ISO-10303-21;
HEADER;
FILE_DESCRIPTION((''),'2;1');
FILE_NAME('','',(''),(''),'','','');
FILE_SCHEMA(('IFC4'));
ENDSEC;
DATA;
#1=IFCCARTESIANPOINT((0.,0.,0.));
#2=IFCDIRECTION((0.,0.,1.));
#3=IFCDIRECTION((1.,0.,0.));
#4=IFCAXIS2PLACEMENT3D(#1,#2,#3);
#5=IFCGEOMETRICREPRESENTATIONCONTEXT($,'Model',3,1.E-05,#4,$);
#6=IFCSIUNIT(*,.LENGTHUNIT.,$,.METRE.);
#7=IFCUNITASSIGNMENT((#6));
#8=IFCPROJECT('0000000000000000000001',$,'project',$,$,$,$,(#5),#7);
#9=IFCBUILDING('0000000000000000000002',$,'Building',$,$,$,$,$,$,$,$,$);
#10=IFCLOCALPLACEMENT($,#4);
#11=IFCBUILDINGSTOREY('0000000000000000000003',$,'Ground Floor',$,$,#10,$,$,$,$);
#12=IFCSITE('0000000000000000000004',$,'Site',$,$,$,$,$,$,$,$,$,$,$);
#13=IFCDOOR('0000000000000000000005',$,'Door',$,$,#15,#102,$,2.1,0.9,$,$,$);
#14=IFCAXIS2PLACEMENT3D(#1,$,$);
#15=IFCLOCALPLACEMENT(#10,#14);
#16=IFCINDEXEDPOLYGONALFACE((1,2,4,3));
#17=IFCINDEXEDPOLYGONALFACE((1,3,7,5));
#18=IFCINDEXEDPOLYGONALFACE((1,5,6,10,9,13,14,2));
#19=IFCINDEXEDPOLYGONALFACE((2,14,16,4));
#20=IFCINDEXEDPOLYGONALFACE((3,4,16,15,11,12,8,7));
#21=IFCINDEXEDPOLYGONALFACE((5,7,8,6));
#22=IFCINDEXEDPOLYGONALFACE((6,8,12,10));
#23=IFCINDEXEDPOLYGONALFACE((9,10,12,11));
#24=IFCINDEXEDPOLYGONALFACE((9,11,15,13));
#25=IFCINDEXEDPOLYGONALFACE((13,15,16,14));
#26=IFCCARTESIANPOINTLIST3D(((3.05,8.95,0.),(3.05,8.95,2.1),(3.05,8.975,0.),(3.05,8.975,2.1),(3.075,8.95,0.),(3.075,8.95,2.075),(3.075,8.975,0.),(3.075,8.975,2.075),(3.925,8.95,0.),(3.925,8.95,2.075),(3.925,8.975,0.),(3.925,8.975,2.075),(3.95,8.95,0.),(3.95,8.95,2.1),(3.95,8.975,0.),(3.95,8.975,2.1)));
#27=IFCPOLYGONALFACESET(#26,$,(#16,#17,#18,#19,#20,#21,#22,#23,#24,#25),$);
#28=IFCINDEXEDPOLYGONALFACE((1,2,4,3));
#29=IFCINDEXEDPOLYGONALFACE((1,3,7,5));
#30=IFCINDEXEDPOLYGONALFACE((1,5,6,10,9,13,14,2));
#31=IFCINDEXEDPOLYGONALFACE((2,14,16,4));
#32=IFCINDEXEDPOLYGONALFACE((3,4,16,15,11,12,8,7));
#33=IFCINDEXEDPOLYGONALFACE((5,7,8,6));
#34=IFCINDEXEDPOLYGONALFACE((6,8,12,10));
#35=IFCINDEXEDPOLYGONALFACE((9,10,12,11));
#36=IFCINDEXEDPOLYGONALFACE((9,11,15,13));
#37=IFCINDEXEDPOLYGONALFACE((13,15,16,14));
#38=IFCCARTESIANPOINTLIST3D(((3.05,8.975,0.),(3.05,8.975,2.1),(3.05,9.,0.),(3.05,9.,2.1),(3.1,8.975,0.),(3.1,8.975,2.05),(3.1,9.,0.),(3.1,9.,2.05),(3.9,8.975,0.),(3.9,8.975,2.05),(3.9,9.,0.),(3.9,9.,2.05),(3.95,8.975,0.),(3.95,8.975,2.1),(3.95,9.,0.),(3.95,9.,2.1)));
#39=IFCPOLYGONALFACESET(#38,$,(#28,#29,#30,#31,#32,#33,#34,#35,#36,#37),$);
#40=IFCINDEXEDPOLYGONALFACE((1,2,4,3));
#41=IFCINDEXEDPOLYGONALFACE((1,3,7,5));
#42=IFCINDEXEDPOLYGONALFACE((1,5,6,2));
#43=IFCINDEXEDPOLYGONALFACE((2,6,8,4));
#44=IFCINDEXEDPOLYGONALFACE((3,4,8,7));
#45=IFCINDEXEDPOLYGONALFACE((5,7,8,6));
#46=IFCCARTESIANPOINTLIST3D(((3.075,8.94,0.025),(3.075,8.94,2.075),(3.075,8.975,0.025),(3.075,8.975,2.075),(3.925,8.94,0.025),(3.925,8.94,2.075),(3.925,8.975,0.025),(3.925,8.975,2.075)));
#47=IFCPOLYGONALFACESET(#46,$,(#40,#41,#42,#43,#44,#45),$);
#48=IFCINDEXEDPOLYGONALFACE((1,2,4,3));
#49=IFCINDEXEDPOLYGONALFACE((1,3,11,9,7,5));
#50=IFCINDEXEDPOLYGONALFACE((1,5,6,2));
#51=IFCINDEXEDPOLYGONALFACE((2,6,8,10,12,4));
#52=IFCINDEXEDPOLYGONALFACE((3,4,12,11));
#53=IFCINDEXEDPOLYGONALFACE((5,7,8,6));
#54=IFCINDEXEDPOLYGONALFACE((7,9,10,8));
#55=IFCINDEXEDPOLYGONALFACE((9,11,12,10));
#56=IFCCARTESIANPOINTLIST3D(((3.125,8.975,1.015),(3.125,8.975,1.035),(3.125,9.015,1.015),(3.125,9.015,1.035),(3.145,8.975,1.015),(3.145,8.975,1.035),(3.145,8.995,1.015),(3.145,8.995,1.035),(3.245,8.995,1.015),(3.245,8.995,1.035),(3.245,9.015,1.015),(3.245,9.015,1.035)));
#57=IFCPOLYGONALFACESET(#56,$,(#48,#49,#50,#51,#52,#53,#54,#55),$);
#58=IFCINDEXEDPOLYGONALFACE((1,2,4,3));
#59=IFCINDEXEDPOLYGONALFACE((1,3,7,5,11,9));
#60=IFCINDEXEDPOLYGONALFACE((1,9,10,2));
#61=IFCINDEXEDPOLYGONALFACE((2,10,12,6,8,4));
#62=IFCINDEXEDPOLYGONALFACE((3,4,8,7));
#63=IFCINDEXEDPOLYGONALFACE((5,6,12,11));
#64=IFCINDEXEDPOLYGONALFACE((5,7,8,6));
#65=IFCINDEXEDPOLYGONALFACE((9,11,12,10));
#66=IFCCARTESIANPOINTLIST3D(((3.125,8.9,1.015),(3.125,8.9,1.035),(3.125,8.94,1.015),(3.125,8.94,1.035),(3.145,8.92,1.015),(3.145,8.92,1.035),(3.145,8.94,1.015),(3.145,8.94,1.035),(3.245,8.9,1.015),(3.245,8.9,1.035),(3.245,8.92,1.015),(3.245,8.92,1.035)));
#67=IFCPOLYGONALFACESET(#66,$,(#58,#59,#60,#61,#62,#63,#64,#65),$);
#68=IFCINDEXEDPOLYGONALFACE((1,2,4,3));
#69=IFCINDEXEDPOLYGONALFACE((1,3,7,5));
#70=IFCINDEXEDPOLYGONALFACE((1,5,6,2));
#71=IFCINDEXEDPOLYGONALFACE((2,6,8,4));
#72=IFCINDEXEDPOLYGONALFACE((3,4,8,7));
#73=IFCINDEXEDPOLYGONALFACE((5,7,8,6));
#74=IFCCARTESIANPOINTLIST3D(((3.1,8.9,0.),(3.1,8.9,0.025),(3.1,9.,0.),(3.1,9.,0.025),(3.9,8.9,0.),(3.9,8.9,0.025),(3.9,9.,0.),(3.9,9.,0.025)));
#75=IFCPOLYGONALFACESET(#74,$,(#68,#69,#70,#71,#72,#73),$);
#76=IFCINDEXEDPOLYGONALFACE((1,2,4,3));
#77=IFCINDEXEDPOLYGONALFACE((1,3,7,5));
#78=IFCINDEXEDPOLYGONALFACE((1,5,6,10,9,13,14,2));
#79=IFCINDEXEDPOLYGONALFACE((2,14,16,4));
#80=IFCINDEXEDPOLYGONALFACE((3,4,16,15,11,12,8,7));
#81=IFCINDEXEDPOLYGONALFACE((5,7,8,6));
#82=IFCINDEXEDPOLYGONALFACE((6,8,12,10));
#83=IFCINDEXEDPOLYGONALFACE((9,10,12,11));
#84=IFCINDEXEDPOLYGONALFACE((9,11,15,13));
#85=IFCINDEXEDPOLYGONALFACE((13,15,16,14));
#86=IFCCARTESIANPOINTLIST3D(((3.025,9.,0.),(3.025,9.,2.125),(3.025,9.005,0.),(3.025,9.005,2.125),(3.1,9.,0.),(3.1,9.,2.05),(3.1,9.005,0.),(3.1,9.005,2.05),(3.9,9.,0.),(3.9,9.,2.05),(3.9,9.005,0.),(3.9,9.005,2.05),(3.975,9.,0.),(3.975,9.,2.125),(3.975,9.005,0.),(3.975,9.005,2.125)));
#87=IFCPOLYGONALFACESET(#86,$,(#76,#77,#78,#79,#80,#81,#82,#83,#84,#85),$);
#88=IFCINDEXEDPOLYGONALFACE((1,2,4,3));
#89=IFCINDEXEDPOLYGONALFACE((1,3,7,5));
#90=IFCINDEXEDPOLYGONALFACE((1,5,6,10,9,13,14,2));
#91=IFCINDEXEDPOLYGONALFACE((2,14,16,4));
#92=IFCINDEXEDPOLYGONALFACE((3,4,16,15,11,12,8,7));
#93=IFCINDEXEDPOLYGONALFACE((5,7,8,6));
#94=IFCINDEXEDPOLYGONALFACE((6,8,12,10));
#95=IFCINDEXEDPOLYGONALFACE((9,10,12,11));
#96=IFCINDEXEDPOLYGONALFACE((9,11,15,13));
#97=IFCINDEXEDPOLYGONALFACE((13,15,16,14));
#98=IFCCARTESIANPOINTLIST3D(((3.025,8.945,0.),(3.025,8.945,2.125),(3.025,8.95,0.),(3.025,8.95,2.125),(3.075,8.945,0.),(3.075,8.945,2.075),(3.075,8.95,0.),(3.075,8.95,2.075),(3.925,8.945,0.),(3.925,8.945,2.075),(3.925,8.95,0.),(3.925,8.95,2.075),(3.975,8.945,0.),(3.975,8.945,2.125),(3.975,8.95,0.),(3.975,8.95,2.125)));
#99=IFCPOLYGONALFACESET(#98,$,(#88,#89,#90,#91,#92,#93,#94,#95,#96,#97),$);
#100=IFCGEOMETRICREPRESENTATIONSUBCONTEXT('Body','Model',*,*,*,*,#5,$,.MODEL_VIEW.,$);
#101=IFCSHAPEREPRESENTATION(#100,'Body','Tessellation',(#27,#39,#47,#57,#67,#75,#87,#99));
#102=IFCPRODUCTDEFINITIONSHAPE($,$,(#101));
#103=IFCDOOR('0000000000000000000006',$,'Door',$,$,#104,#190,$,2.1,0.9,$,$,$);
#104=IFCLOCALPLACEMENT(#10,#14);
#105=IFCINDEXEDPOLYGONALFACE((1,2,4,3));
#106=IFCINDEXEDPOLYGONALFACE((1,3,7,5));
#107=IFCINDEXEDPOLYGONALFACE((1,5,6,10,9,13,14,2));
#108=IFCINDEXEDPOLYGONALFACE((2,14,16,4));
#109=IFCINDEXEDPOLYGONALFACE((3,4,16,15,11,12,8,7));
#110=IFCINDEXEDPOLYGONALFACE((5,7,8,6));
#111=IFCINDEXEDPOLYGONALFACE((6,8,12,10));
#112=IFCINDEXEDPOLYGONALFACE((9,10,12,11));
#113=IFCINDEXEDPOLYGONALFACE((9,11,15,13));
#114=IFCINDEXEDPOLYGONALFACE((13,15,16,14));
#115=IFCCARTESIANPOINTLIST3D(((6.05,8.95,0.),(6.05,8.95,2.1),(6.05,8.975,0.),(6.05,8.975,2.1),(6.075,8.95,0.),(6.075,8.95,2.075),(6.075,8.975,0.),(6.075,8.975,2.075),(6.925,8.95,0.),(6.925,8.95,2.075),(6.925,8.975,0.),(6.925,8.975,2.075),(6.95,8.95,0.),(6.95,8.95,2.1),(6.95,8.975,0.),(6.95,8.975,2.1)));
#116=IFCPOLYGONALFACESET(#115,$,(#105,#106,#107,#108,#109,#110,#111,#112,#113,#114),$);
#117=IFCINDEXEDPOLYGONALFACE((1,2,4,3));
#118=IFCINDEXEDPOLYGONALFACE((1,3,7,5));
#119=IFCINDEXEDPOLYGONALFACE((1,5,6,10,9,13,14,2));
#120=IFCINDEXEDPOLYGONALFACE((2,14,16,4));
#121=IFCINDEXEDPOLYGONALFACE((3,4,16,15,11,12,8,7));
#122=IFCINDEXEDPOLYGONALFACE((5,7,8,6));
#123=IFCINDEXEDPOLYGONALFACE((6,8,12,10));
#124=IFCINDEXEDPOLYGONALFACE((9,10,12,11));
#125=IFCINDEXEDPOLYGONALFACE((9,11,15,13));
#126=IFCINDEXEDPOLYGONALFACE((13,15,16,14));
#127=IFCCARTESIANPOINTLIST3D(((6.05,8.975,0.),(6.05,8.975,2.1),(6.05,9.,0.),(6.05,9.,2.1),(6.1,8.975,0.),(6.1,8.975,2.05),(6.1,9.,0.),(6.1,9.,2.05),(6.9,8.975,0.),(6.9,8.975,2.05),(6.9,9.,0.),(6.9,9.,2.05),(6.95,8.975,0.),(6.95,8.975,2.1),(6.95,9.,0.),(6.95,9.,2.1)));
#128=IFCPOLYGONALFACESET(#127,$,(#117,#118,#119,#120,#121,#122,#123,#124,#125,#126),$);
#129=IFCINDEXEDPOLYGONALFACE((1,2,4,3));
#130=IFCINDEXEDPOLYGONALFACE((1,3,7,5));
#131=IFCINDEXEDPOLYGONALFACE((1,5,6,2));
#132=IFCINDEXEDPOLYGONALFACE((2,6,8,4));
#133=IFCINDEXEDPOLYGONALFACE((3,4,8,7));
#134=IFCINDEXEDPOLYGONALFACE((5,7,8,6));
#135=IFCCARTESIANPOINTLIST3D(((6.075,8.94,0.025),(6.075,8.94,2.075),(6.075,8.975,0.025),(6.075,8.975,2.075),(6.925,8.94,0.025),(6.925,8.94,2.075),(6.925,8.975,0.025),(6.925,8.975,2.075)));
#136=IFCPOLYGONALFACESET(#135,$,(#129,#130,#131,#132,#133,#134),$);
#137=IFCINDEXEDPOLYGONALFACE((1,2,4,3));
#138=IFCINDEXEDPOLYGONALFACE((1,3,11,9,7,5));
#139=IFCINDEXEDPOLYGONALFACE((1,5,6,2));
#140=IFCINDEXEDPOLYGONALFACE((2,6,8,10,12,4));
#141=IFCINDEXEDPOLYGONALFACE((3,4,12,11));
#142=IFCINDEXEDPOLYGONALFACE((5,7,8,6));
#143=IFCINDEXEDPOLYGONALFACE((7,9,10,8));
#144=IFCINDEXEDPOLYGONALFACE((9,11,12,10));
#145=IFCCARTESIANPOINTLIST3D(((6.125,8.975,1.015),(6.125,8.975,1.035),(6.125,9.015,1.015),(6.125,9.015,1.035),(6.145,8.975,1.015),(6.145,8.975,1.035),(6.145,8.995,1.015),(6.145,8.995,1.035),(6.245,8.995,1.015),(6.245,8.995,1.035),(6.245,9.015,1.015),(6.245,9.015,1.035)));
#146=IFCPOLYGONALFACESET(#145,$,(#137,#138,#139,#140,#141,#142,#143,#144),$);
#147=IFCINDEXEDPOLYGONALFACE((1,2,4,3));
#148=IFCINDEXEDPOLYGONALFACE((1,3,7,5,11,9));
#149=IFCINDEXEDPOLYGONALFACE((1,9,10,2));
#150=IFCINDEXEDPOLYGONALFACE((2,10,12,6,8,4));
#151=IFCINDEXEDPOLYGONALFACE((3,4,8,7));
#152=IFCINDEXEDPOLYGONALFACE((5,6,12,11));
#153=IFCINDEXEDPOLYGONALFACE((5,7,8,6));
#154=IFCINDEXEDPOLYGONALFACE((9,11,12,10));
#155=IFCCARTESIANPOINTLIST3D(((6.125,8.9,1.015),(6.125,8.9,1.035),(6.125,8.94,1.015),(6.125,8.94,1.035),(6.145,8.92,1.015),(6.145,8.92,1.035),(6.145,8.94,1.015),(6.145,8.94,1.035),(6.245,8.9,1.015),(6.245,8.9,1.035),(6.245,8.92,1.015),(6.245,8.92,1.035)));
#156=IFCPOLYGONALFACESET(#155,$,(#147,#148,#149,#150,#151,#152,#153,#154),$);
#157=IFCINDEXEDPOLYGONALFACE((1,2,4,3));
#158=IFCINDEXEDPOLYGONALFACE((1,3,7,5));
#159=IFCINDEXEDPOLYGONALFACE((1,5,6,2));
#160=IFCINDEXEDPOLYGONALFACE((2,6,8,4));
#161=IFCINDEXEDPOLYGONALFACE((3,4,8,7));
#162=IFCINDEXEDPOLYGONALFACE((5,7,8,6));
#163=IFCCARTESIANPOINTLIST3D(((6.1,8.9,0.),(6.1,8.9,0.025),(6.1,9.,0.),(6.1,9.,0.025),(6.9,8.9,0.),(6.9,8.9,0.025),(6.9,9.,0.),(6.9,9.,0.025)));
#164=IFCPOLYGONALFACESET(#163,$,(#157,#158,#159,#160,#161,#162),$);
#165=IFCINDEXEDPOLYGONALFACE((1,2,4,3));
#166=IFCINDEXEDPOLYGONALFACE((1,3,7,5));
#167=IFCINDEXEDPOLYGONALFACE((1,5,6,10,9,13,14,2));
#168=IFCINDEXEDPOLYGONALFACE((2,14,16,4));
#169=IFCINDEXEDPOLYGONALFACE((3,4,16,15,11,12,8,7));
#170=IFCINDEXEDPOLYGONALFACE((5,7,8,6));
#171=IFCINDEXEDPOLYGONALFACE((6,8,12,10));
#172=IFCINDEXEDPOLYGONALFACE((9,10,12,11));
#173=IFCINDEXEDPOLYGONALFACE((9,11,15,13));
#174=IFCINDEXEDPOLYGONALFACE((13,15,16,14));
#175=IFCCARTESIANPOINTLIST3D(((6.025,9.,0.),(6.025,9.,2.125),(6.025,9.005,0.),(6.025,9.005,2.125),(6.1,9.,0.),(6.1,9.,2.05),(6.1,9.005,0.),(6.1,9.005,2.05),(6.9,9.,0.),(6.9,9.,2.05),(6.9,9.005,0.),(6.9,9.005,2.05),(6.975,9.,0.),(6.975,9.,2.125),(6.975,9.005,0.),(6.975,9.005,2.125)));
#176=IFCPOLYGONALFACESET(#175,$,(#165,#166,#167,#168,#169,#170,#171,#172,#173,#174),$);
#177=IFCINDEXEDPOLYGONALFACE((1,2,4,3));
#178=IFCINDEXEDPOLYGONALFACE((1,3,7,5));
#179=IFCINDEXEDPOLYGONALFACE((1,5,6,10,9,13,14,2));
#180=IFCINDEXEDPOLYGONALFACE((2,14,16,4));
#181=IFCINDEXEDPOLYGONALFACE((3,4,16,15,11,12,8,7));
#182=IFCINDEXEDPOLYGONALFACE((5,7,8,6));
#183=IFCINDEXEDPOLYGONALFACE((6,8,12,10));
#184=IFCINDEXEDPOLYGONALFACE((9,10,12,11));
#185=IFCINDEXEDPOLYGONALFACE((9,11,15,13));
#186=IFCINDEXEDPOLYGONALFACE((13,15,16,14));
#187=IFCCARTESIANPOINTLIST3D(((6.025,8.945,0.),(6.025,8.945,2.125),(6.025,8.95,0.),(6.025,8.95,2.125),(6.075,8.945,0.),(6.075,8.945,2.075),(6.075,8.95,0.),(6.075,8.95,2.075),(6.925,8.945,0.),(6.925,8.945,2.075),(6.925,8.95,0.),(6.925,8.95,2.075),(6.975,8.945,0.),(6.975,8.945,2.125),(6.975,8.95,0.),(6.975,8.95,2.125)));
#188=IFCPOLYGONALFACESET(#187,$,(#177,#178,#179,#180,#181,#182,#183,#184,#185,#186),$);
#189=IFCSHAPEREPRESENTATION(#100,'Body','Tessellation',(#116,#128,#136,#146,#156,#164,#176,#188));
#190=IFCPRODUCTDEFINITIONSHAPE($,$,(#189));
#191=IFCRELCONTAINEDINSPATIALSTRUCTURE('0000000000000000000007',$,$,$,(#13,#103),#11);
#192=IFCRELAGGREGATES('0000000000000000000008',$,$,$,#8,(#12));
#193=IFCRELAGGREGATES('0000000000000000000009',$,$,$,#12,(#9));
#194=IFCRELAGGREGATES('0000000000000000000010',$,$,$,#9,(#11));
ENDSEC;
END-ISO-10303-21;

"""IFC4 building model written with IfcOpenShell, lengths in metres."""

from ifc_helpers import new_model, si_unit, frame, origin_with_axes, place, context, subcontext, project, spatial, line, indexed_curve, outline, extrude, element, save


model = new_model("IFC4")

# Units and contexts
model_context = context("Model", 3, precision=1e-05, world=origin_with_axes())
body_context = subcontext(model_context, "Body", "Model", "MODEL_VIEW")
ifc_project = project(units=[si_unit("LENGTHUNIT", "METRE")], contexts=[model_context])

# Site, building, storey
site = spatial("IfcSite", under=ifc_project, Name="Site")
building = spatial("IfcBuilding", under=site, Name="Building")
storey_placement = place(None, origin_with_axes())
storey = spatial("IfcBuildingStorey", under=building, at=storey_placement, Name="Ground Floor")

# Doors
door_1_placement = place(storey_placement, frame((3.95, 9.0, 0.0), z_axis=(0.0, 0.0, 1.0), x_axis=(-1.0, 0.0, 0.0)))
element("IfcDoor", 1, at=door_1_placement, inside=storey, Name="Door", OverallHeight=2.1, OverallWidth=0.9, context=body_context, shape_type="SweptSolid", body=[
    extrude(outline(indexed_curve([(0.0, 0.0), (0.0, 2.1), (0.9, 2.1), (0.9, 0.0), (0.875, 0.0), (0.875, 2.075), (0.025, 2.075), (0.025, 0.0)], segments=[line(1, 2, 3, 4, 5, 6, 7, 8, 1)])), frame((0.0, 0.025, 0.0), z_axis=(0.0, -1.0, 0.0), x_axis=(1.0, 0.0, 0.0)), (0.0, 0.0, -1.0), 0.025),
    extrude(outline(indexed_curve([(0.0, 0.0), (0.0, 2.1), (0.9, 2.1), (0.9, 0.0), (0.85, 0.0), (0.85, 2.05), (0.05, 2.05), (0.05, 0.0)], segments=[line(1, 2, 3, 4, 5, 6, 7, 8, 1)])), frame((0.0, 0.0, 0.0), z_axis=(0.0, -1.0, 0.0), x_axis=(1.0, 0.0, 0.0)), (0.0, 0.0, -1.0), 0.025),
    extrude(outline(indexed_curve([(0.0, 0.0), (0.85, 0.0), (0.85, 0.035), (0.0, 0.035)], segments=[line(1, 2, 3, 4, 1)])), frame((0.025, 0.025, 0.025), z_axis=(0.0, 0.0, 1.0), x_axis=(1.0, 0.0, 0.0)), (0.0, 0.0, 1.0), 2.05),
    extrude(outline(indexed_curve([(0.0, 0.0), (0.0, -0.04), (-0.12, -0.04), (-0.12, -0.02), (-0.02, -0.02), (-0.02, 0.0)], segments=[line(1, 2, 3, 4, 5, 6, 1)])), frame((0.825, 0.025, 1.015), z_axis=(0.0, 0.0, 1.0), x_axis=(1.0, 0.0, 0.0)), (0.0, 0.0, 1.0), 0.02),
    extrude(outline(indexed_curve([(0.0, 0.0), (0.0, 0.04), (-0.12, 0.04), (-0.12, 0.02), (-0.02, 0.02), (-0.02, 0.0)], segments=[line(1, 2, 3, 4, 5, 6, 1)])), frame((0.825, 0.06, 1.015), z_axis=(0.0, 0.0, 1.0), x_axis=(1.0, 0.0, 0.0)), (0.0, 0.0, 1.0), 0.02),
    extrude(outline(indexed_curve([(0.0, 0.0), (0.8, 0.0), (0.8, 0.1), (0.0, 0.1)], segments=[line(1, 2, 3, 4, 1)])), frame((0.05, 0.0, 0.0), z_axis=(0.0, 0.0, 1.0), x_axis=(1.0, 0.0, 0.0)), (0.0, 0.0, 1.0), 0.025),
    extrude(outline(indexed_curve([(0.0, 0.0), (0.0, 2.125), (0.95, 2.125), (0.95, 0.0), (0.875, 0.0), (0.875, 2.05), (0.075, 2.05), (0.075, 0.0)], segments=[line(1, 2, 3, 4, 5, 6, 7, 8, 1)])), frame((-0.025, -0.005, 0.0), z_axis=(0.0, -1.0, 0.0), x_axis=(1.0, 0.0, 0.0)), (0.0, 0.0, -1.0), 0.005),
    extrude(outline(indexed_curve([(0.0, 0.0), (0.0, 2.125), (0.95, 2.125), (0.95, 0.0), (0.9, 0.0), (0.9, 2.075), (0.05, 2.075), (0.05, 0.0)], segments=[line(1, 2, 3, 4, 5, 6, 7, 8, 1)])), frame((-0.025, 0.05, 0.0), z_axis=(0.0, -1.0, 0.0), x_axis=(1.0, 0.0, 0.0)), (0.0, 0.0, -1.0), 0.005),
])
door_2_placement = place(storey_placement, frame((6.95, 9.0, 0.0), z_axis=(0.0, 0.0, 1.0), x_axis=(-1.0, 0.0, 0.0)))
element("IfcDoor", 2, at=door_2_placement, inside=storey, Name="Door", OverallHeight=2.1, OverallWidth=0.9, context=body_context, shape_type="SweptSolid", body=[
    extrude(outline(indexed_curve([(0.0, 0.0), (0.0, 2.1), (0.9, 2.1), (0.9, 0.0), (0.875, 0.0), (0.875, 2.075), (0.025, 2.075), (0.025, 0.0)], segments=[line(1, 2, 3, 4, 5, 6, 7, 8, 1)])), frame((0.0, 0.025, 0.0), z_axis=(0.0, -1.0, 0.0), x_axis=(1.0, 0.0, 0.0)), (0.0, 0.0, -1.0), 0.025),
    extrude(outline(indexed_curve([(0.0, 0.0), (0.0, 2.1), (0.9, 2.1), (0.9, 0.0), (0.85, 0.0), (0.85, 2.05), (0.05, 2.05), (0.05, 0.0)], segments=[line(1, 2, 3, 4, 5, 6, 7, 8, 1)])), frame((0.0, 0.0, 0.0), z_axis=(0.0, -1.0, 0.0), x_axis=(1.0, 0.0, 0.0)), (0.0, 0.0, -1.0), 0.025),
    extrude(outline(indexed_curve([(0.0, 0.0), (0.85, 0.0), (0.85, 0.035), (0.0, 0.035)], segments=[line(1, 2, 3, 4, 1)])), frame((0.025, 0.025, 0.025), z_axis=(0.0, 0.0, 1.0), x_axis=(1.0, 0.0, 0.0)), (0.0, 0.0, 1.0), 2.05),
    extrude(outline(indexed_curve([(0.0, 0.0), (0.0, -0.04), (-0.12, -0.04), (-0.12, -0.02), (-0.02, -0.02), (-0.02, 0.0)], segments=[line(1, 2, 3, 4, 5, 6, 1)])), frame((0.825, 0.025, 1.015), z_axis=(0.0, 0.0, 1.0), x_axis=(1.0, 0.0, 0.0)), (0.0, 0.0, 1.0), 0.02),
    extrude(outline(indexed_curve([(0.0, 0.0), (0.0, 0.04), (-0.12, 0.04), (-0.12, 0.02), (-0.02, 0.02), (-0.02, 0.0)], segments=[line(1, 2, 3, 4, 5, 6, 1)])), frame((0.825, 0.06, 1.015), z_axis=(0.0, 0.0, 1.0), x_axis=(1.0, 0.0, 0.0)), (0.0, 0.0, 1.0), 0.02),
    extrude(outline(indexed_curve([(0.0, 0.0), (0.8, 0.0), (0.8, 0.1), (0.0, 0.1)], segments=[line(1, 2, 3, 4, 1)])), frame((0.05, 0.0, 0.0), z_axis=(0.0, 0.0, 1.0), x_axis=(1.0, 0.0, 0.0)), (0.0, 0.0, 1.0), 0.025),
    extrude(outline(indexed_curve([(0.0, 0.0), (0.0, 2.125), (0.95, 2.125), (0.95, 0.0), (0.875, 0.0), (0.875, 2.05), (0.075, 2.05), (0.075, 0.0)], segments=[line(1, 2, 3, 4, 5, 6, 7, 8, 1)])), frame((-0.025, -0.005, 0.0), z_axis=(0.0, -1.0, 0.0), x_axis=(1.0, 0.0, 0.0)), (0.0, 0.0, -1.0), 0.005),
    extrude(outline(indexed_curve([(0.0, 0.0), (0.0, 2.125), (0.95, 2.125), (0.95, 0.0), (0.9, 0.0), (0.9, 2.075), (0.05, 2.075), (0.05, 0.0)], segments=[line(1, 2, 3, 4, 5, 6, 7, 8, 1)])), frame((-0.025, 0.05, 0.0), z_axis=(0.0, -1.0, 0.0), x_axis=(1.0, 0.0, 0.0)), (0.0, 0.0, -1.0), 0.005),
])

save(model, "model.ifc")
